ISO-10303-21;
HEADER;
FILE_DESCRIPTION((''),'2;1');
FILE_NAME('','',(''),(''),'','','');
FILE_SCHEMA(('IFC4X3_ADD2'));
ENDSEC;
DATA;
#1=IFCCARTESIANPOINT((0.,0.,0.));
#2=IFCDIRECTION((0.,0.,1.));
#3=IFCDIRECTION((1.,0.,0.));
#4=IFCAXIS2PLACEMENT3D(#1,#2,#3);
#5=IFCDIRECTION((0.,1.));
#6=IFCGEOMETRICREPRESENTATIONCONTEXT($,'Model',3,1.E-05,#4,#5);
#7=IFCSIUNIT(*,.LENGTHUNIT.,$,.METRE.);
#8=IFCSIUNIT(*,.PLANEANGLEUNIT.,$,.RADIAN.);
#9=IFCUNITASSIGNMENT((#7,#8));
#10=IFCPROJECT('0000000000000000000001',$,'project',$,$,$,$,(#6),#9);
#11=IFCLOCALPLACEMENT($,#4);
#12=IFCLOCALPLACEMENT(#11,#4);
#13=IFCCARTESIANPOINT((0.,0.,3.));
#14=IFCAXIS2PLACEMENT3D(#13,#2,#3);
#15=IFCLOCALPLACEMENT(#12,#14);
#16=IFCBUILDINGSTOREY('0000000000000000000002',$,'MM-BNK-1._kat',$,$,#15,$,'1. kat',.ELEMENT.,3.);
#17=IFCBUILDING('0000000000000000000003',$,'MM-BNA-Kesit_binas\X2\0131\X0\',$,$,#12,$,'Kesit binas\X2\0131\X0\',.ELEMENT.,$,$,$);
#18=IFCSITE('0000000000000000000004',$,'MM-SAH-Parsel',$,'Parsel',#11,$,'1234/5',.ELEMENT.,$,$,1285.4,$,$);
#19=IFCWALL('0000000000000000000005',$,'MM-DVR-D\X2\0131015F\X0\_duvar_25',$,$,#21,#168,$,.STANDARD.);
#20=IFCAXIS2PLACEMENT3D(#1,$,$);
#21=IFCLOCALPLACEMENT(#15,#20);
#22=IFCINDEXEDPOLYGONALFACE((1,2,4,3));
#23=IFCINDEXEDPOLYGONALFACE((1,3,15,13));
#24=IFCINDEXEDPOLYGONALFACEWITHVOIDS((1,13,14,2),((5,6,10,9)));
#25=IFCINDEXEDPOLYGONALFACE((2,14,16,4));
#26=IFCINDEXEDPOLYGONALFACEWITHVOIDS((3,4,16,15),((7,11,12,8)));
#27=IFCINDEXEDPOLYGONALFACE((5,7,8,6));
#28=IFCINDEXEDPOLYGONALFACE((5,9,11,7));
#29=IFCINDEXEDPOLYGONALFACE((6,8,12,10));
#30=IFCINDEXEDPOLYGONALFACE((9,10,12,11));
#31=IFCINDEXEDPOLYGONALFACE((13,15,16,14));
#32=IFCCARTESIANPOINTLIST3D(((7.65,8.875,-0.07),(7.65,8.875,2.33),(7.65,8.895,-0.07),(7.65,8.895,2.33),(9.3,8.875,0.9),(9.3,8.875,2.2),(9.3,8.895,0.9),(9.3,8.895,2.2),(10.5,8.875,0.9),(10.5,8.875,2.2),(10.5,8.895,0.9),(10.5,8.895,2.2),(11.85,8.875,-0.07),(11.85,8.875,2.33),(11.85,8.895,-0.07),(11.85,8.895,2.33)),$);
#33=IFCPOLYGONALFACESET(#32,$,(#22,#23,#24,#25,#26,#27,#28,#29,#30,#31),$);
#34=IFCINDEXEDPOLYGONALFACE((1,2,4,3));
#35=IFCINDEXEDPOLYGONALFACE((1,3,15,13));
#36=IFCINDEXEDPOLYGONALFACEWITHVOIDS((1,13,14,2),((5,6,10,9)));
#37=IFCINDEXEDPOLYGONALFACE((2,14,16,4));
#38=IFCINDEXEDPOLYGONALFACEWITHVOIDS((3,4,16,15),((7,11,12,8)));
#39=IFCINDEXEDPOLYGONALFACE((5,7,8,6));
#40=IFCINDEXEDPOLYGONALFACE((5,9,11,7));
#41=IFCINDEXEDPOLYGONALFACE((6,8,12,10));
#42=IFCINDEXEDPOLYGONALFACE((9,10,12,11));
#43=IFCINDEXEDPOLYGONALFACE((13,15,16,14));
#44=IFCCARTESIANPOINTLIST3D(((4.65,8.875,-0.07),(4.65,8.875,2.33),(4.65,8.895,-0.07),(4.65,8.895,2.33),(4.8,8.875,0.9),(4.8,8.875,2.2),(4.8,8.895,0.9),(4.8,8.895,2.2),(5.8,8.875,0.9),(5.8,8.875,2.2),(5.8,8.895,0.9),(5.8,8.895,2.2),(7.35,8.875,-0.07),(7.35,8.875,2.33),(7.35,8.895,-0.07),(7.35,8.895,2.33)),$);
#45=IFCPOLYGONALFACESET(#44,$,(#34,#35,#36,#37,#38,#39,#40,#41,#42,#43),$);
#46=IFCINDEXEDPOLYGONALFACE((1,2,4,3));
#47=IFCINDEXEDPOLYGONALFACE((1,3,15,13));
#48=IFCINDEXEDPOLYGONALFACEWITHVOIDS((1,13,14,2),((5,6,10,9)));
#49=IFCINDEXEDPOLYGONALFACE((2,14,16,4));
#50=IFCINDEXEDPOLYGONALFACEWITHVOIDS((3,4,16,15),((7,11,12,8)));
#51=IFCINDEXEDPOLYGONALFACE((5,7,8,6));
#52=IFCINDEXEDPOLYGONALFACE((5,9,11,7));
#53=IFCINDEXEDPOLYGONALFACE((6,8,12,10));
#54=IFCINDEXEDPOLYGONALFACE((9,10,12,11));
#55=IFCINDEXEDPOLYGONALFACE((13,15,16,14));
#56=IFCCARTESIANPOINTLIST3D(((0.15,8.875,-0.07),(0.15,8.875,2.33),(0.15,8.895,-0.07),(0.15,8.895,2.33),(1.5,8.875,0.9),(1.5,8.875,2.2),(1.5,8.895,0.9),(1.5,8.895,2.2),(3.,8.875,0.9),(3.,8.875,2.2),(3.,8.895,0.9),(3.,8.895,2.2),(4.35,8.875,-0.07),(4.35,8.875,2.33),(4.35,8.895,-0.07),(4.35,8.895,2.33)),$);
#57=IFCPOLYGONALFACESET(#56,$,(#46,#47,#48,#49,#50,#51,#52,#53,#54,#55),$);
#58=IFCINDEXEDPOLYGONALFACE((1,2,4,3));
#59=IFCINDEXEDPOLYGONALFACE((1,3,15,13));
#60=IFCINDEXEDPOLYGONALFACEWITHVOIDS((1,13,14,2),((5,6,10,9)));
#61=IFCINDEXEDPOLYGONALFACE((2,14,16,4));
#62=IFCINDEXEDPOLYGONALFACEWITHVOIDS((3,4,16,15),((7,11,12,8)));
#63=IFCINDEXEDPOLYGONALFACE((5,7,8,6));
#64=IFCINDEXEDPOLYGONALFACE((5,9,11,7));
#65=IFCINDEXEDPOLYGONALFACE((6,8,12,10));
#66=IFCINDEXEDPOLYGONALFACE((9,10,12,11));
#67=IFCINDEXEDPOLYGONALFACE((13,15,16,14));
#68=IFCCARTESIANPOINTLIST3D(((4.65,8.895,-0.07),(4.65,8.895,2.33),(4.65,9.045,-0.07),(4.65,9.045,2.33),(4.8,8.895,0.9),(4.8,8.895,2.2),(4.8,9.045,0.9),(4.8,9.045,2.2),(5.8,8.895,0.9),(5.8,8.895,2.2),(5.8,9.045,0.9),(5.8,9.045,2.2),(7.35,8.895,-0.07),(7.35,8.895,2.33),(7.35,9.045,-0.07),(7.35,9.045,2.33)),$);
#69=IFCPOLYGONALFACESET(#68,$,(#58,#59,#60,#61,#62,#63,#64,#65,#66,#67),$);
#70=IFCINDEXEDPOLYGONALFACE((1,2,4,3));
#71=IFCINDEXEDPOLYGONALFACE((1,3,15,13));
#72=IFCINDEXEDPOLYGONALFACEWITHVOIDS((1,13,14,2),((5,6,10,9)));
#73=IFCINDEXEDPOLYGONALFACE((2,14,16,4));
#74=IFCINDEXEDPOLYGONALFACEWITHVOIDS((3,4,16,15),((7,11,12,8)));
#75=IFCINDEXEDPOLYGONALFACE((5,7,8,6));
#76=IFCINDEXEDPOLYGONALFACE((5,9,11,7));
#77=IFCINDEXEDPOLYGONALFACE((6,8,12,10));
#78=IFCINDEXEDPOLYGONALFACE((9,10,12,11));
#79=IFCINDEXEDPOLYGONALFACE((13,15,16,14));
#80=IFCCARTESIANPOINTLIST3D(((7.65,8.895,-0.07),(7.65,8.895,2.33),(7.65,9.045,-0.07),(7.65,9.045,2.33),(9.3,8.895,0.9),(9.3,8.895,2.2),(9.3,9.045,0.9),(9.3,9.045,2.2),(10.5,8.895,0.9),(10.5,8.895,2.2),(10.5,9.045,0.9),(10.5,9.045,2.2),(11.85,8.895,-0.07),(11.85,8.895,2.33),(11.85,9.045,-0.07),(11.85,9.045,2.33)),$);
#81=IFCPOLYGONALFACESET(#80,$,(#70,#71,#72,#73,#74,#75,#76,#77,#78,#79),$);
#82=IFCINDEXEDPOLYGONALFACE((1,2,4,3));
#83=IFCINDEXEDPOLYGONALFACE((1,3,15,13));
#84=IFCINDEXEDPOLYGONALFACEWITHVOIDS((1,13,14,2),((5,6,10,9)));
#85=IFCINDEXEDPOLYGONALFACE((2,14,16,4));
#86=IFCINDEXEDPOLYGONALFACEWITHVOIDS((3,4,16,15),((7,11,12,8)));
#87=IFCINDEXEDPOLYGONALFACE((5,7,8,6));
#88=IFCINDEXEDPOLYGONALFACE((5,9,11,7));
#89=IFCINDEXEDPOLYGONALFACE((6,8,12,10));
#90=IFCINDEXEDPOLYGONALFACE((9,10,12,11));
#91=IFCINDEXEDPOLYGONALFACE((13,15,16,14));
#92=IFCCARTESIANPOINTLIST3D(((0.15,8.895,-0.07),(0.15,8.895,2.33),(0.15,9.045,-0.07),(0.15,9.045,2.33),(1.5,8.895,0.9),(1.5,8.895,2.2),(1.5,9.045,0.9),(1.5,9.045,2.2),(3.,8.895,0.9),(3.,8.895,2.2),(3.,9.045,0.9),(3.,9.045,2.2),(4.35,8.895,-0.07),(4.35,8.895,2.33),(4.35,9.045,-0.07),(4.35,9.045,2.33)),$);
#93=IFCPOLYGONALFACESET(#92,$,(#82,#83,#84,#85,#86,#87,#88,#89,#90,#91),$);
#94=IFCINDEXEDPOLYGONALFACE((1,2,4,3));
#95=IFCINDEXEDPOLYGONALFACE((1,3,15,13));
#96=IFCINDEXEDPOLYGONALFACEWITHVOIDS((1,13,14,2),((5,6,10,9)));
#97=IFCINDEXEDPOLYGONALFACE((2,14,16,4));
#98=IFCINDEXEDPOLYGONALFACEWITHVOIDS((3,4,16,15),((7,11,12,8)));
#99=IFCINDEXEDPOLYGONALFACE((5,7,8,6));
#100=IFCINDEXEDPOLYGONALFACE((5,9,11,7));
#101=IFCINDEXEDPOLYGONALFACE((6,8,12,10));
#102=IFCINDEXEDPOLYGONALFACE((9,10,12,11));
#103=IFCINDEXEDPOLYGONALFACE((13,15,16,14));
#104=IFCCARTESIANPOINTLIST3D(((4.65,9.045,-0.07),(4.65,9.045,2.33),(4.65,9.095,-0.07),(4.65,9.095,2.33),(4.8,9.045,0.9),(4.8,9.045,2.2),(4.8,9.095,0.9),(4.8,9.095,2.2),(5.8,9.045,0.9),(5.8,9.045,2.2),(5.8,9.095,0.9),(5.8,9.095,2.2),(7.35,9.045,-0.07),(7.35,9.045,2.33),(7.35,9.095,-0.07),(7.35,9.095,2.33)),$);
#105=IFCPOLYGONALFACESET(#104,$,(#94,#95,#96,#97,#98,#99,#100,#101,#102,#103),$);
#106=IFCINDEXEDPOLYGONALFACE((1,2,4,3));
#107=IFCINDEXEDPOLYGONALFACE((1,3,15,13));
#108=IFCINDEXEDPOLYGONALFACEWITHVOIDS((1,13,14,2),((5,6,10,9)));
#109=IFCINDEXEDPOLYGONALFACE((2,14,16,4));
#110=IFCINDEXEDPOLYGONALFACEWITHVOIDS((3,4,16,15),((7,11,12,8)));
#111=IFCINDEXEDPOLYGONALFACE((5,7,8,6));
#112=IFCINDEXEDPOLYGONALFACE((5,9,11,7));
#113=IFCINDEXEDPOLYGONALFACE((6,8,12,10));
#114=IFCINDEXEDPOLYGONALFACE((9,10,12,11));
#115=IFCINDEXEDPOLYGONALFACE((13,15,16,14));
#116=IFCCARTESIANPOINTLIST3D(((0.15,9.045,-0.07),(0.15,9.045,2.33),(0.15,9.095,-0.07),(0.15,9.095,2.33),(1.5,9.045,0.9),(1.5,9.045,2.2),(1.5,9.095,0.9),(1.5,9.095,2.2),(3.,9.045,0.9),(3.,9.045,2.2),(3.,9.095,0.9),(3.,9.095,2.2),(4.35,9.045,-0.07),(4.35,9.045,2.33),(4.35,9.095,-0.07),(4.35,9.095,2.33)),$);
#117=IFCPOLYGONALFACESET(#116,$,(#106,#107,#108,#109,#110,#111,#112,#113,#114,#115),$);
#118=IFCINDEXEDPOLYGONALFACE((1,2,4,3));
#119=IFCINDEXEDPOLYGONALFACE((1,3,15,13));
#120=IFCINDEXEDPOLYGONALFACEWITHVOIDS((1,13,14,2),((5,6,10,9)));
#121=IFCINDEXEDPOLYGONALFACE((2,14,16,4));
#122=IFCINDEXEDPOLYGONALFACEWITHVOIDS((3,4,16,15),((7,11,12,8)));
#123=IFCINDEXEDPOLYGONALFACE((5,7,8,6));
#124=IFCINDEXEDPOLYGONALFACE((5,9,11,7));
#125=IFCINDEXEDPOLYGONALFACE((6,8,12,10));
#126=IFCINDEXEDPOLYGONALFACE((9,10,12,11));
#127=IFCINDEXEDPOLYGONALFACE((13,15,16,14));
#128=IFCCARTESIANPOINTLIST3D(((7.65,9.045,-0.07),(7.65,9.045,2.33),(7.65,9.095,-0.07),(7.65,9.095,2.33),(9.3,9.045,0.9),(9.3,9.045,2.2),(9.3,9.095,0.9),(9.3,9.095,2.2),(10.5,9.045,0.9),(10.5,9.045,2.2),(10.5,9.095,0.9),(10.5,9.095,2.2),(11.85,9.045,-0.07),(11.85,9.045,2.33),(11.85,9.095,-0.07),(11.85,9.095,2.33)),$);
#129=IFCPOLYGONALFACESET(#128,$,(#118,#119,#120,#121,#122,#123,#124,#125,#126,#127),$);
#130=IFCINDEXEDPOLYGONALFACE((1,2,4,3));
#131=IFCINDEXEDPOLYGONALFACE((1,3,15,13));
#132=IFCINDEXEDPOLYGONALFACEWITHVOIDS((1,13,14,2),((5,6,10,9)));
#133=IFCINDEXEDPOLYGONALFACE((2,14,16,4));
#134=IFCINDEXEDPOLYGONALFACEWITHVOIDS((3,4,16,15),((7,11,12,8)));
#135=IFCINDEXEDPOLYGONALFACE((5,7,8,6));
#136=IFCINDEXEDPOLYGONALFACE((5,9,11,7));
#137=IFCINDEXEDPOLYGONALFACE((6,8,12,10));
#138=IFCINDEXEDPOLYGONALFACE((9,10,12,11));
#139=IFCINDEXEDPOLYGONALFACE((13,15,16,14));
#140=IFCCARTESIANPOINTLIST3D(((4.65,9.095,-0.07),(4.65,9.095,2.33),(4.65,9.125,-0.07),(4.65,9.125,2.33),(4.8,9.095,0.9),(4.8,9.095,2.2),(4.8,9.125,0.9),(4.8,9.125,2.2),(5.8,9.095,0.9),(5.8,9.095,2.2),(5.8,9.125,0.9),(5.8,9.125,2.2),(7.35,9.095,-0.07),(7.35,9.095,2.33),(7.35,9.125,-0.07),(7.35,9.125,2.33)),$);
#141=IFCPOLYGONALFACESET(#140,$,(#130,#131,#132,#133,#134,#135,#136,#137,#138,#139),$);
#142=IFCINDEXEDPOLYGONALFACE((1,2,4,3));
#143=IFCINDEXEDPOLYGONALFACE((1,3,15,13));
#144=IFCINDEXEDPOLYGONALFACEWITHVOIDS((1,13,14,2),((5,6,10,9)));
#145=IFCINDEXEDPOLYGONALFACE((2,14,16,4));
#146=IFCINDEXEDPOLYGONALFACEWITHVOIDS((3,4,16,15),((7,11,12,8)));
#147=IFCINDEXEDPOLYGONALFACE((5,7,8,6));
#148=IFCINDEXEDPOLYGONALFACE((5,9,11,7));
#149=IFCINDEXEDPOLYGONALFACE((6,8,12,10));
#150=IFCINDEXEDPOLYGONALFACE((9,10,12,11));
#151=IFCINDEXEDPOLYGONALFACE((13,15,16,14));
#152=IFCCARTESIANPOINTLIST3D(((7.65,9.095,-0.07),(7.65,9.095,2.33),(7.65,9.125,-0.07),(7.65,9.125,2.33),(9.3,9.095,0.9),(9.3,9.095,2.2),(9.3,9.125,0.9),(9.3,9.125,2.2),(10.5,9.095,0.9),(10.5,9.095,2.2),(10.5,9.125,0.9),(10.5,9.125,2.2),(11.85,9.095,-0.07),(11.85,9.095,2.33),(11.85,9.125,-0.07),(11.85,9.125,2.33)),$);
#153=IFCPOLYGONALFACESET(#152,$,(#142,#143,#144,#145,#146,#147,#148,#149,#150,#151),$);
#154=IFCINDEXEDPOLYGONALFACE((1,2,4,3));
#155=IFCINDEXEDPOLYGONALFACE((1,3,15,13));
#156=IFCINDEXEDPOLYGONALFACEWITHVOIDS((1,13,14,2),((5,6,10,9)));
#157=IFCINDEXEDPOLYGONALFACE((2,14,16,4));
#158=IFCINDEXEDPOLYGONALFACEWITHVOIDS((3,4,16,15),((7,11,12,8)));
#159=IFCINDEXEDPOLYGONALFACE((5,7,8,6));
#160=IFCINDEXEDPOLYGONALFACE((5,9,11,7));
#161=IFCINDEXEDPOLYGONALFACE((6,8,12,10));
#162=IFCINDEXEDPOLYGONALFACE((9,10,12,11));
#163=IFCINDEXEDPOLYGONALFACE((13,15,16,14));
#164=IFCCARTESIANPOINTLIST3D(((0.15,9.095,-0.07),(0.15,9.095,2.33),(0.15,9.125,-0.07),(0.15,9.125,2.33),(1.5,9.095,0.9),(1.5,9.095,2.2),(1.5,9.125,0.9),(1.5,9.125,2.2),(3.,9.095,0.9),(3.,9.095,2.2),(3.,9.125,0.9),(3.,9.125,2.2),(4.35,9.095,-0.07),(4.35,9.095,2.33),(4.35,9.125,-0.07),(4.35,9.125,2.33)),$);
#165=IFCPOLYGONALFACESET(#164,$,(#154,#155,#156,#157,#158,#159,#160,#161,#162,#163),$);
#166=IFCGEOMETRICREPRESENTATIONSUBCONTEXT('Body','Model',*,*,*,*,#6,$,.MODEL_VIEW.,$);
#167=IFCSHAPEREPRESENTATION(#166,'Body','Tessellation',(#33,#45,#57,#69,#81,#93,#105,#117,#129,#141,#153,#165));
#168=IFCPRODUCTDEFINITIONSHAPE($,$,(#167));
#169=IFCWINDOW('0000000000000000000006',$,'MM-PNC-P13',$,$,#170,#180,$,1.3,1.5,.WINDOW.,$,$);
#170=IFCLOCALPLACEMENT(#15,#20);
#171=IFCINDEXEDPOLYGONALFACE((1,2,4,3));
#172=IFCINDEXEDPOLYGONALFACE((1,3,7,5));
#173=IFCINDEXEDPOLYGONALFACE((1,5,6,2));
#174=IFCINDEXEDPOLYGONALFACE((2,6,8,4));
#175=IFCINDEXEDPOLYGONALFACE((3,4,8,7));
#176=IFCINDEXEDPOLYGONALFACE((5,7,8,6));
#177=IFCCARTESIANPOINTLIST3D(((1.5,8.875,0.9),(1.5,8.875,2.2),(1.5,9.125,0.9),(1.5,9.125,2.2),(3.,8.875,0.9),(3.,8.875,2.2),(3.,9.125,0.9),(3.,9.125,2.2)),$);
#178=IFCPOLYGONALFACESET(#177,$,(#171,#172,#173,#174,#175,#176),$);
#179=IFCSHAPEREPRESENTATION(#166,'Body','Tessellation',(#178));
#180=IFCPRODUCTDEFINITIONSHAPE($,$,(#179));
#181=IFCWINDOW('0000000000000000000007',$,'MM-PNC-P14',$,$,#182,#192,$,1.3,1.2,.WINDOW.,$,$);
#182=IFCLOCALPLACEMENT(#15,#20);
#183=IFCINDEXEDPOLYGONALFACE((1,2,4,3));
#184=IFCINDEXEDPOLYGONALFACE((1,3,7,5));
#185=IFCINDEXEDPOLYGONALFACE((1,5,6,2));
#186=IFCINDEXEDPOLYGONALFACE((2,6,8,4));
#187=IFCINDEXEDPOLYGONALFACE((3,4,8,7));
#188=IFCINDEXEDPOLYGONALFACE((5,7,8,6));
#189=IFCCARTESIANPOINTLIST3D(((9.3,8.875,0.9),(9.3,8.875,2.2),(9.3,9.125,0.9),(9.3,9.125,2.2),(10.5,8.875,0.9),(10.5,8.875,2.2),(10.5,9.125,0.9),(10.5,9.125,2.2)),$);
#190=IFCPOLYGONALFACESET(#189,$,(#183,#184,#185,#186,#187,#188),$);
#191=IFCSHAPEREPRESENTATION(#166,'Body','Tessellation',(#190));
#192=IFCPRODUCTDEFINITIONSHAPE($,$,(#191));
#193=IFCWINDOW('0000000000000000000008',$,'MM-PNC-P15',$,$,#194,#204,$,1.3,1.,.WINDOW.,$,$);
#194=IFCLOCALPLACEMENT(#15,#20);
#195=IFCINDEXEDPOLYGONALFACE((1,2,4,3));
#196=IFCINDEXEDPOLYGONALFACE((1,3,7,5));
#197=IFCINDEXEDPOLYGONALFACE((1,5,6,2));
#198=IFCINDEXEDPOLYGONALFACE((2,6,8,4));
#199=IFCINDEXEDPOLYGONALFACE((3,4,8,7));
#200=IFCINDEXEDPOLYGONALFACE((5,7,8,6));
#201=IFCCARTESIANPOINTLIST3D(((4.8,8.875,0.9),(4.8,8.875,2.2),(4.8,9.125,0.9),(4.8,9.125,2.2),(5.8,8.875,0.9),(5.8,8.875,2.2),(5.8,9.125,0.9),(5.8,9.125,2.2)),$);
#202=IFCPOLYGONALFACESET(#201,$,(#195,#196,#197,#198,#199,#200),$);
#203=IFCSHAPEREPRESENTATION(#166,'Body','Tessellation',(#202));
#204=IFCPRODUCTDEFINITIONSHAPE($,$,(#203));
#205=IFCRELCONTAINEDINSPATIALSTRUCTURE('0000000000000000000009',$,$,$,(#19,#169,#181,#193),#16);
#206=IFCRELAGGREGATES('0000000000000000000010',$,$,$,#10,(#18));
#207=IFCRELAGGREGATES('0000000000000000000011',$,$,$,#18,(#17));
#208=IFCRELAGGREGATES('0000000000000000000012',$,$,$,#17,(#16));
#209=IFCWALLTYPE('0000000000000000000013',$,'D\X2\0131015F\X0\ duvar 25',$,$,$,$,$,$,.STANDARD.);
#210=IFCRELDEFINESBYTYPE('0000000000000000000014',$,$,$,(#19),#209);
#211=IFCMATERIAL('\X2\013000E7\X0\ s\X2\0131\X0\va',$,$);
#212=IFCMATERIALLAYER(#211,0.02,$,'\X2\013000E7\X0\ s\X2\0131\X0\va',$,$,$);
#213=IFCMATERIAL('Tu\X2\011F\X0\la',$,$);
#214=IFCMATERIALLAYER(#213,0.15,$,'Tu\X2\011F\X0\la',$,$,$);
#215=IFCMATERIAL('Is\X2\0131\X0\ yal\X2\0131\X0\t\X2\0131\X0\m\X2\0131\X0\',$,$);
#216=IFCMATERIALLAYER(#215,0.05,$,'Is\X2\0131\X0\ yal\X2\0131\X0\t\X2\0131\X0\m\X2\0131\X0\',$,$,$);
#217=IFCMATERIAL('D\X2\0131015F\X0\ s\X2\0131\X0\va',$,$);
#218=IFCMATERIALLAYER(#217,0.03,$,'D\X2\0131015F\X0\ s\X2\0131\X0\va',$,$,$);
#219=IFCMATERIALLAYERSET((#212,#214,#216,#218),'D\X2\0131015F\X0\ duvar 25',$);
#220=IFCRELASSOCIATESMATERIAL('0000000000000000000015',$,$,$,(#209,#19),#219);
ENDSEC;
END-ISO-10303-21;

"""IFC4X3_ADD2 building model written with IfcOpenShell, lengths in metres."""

from ifc_helpers import new_model, si_unit, direction, frame, origin_with_axes, place, context, subcontext, project, spatial, polyline, outline, extrude, material, layer, layer_set, type_object, element, fill, save


model = new_model("IFC4X3_ADD2")

# Units and contexts
model_context = context("Model", 3, precision=1e-05, world=origin_with_axes(), true_north=direction((0.0, 1.0)))
body_context = subcontext(model_context, "Body", "Model", "MODEL_VIEW")
ifc_project = project(units=[si_unit("LENGTHUNIT", "METRE"), si_unit("PLANEANGLEUNIT", "RADIAN")], contexts=[model_context])

# Site, building, storey
site_placement = place(None, origin_with_axes())
site = spatial("IfcSite", under=ifc_project, at=site_placement, Name="MM-SAH-Parsel", ObjectType="Parsel", LongName="1234/5", CompositionType="ELEMENT", RefElevation=1285.4)
building_placement = place(site_placement, origin_with_axes())
building = spatial("IfcBuilding", under=site, at=building_placement, Name="MM-BNA-Kesit_binası", LongName="Kesit binası", CompositionType="ELEMENT")
storey_placement = place(building_placement, frame((0.0, 0.0, 3.0), z_axis=(0.0, 0.0, 1.0), x_axis=(1.0, 0.0, 0.0)))
storey = spatial("IfcBuildingStorey", under=building, at=storey_placement, Name="MM-BNK-1._kat", LongName="1. kat", CompositionType="ELEMENT", Elevation=3.0)

# Shared definitions
ifc_material_1 = material(Name="İç sıva")
ifc_layer_1 = layer(ifc_material_1, 0.02, Name="İç sıva")
ifc_material_2 = material(Name="Tuğla")
ifc_layer_2 = layer(ifc_material_2, 0.15, Name="Tuğla")
ifc_material_3 = material(Name="Isı yalıtımı")
ifc_layer_3 = layer(ifc_material_3, 0.05, Name="Isı yalıtımı")
ifc_material_4 = material(Name="Dış sıva")
ifc_layer_4 = layer(ifc_material_4, 0.03, Name="Dış sıva")
ifc_layer_set_1 = layer_set([ifc_layer_1, ifc_layer_2, ifc_layer_3, ifc_layer_4], Name="Dış duvar 25")
wall_type_1 = type_object("IfcWallType", Name="Dış duvar 25", PredefinedType="STANDARD", material=ifc_layer_set_1)

# Wall, openings, windows
wall_1_placement = place(storey_placement, origin_with_axes())
wall_1 = element("IfcWall", 1, at=wall_1_placement, inside=storey, type_object=wall_type_1, material=ifc_layer_set_1, Name="MM-DVR-Dış_duvar_25", PredefinedType="STANDARD", context=body_context, shape_type="SweptSolid", body=[
    extrude(outline(polyline([(11.85, 8.895), (7.65, 8.895), (7.65, 8.875), (11.85, 8.875), (11.85, 8.895)])), frame((0.0, 0.0, -0.07)), (0.0, 0.0, 1.0), 2.4),
    extrude(outline(polyline([(7.35, 8.895), (4.65, 8.895), (4.65, 8.875), (7.35, 8.875), (7.35, 8.895)])), frame((0.0, 0.0, -0.07)), (0.0, 0.0, 1.0), 2.4),
    extrude(outline(polyline([(4.35, 8.895), (0.15, 8.895), (0.15, 8.875), (4.35, 8.875), (4.35, 8.895)])), frame((0.0, 0.0, -0.07)), (0.0, 0.0, 1.0), 2.4),
    extrude(outline(polyline([(7.35, 9.045), (4.65, 9.045), (4.65, 8.895), (7.35, 8.895), (7.35, 9.045)])), frame((0.0, 0.0, -0.07)), (0.0, 0.0, 1.0), 2.4),
    extrude(outline(polyline([(11.85, 9.045), (7.65, 9.045), (7.65, 8.895), (11.85, 8.895), (11.85, 9.045)])), frame((0.0, 0.0, -0.07)), (0.0, 0.0, 1.0), 2.4),
    extrude(outline(polyline([(4.35, 9.045), (0.15, 9.045), (0.15, 8.895), (4.35, 8.895), (4.35, 9.045)])), frame((0.0, 0.0, -0.07)), (0.0, 0.0, 1.0), 2.4),
    extrude(outline(polyline([(7.35, 9.095), (4.65, 9.095), (4.65, 9.045), (7.35, 9.045), (7.35, 9.095)])), frame((0.0, 0.0, -0.07)), (0.0, 0.0, 1.0), 2.4),
    extrude(outline(polyline([(4.35, 9.095), (0.15, 9.095), (0.15, 9.045), (4.35, 9.045), (4.35, 9.095)])), frame((0.0, 0.0, -0.07)), (0.0, 0.0, 1.0), 2.4),
    extrude(outline(polyline([(11.85, 9.095), (7.65, 9.095), (7.65, 9.045), (11.85, 9.045), (11.85, 9.095)])), frame((0.0, 0.0, -0.07)), (0.0, 0.0, 1.0), 2.4),
    extrude(outline(polyline([(7.35, 9.125), (4.65, 9.125), (4.65, 9.095), (7.35, 9.095), (7.35, 9.125)])), frame((0.0, 0.0, -0.07)), (0.0, 0.0, 1.0), 2.4),
    extrude(outline(polyline([(11.85, 9.125), (7.65, 9.125), (7.65, 9.095), (11.85, 9.095), (11.85, 9.125)])), frame((0.0, 0.0, -0.07)), (0.0, 0.0, 1.0), 2.4),
    extrude(outline(polyline([(4.35, 9.125), (0.15, 9.125), (0.15, 9.095), (4.35, 9.095), (4.35, 9.125)])), frame((0.0, 0.0, -0.07)), (0.0, 0.0, 1.0), 2.4),
])
opening_1_placement = place(storey_placement, origin_with_axes())
opening_1 = element("IfcOpeningElement", 2, at=opening_1_placement, cuts=wall_1, PredefinedType="OPENING", context=body_context, shape_type="SweptSolid", body=[
    extrude(outline(polyline([(3.0, 8.875), (1.5, 8.875), (1.5, 9.125), (3.0, 9.125), (3.0, 8.875)])), frame((0.0, 0.0, 0.9)), (0.0, 0.0, 1.0), 1.3),
])
opening_2_placement = place(storey_placement, origin_with_axes())
opening_2 = element("IfcOpeningElement", 3, at=opening_2_placement, cuts=wall_1, PredefinedType="OPENING", context=body_context, shape_type="SweptSolid", body=[
    extrude(outline(polyline([(10.5, 8.875), (9.3, 8.875), (9.3, 9.125), (10.5, 9.125), (10.5, 8.875)])), frame((0.0, 0.0, 0.9)), (0.0, 0.0, 1.0), 1.3),
])
opening_3_placement = place(storey_placement, origin_with_axes())
opening_3 = element("IfcOpeningElement", 4, at=opening_3_placement, cuts=wall_1, PredefinedType="OPENING", context=body_context, shape_type="SweptSolid", body=[
    extrude(outline(polyline([(5.8, 8.875), (4.8, 8.875), (4.8, 9.125), (5.8, 9.125), (5.8, 8.875)])), frame((0.0, 0.0, 0.9)), (0.0, 0.0, 1.0), 1.3),
])
window_1_placement = place(storey_placement, origin_with_axes())
window_1 = element("IfcWindow", 5, at=window_1_placement, inside=storey, Name="MM-PNC-P13", OverallHeight=1.3, OverallWidth=1.5, PredefinedType="WINDOW", context=body_context, shape_type="SweptSolid", body=[
    extrude(outline(polyline([(3.0, 8.875), (1.5, 8.875), (1.5, 9.125), (3.0, 9.125), (3.0, 8.875)])), frame((0.0, 0.0, 0.9)), (0.0, 0.0, 1.0), 1.3),
])
fill(opening_1, window_1)
window_2_placement = place(storey_placement, origin_with_axes())
window_2 = element("IfcWindow", 6, at=window_2_placement, inside=storey, Name="MM-PNC-P14", OverallHeight=1.3, OverallWidth=1.2, PredefinedType="WINDOW", context=body_context, shape_type="SweptSolid", body=[
    extrude(outline(polyline([(10.5, 8.875), (9.3, 8.875), (9.3, 9.125), (10.5, 9.125), (10.5, 8.875)])), frame((0.0, 0.0, 0.9)), (0.0, 0.0, 1.0), 1.3),
])
fill(opening_2, window_2)
window_3_placement = place(storey_placement, origin_with_axes())
window_3 = element("IfcWindow", 7, at=window_3_placement, inside=storey, Name="MM-PNC-P15", OverallHeight=1.3, OverallWidth=1.0, PredefinedType="WINDOW", context=body_context, shape_type="SweptSolid", body=[
    extrude(outline(polyline([(5.8, 8.875), (4.8, 8.875), (4.8, 9.125), (5.8, 9.125), (5.8, 8.875)])), frame((0.0, 0.0, 0.9)), (0.0, 0.0, 1.0), 1.3),
])
fill(opening_3, window_3)

save(model, "model.ifc")
